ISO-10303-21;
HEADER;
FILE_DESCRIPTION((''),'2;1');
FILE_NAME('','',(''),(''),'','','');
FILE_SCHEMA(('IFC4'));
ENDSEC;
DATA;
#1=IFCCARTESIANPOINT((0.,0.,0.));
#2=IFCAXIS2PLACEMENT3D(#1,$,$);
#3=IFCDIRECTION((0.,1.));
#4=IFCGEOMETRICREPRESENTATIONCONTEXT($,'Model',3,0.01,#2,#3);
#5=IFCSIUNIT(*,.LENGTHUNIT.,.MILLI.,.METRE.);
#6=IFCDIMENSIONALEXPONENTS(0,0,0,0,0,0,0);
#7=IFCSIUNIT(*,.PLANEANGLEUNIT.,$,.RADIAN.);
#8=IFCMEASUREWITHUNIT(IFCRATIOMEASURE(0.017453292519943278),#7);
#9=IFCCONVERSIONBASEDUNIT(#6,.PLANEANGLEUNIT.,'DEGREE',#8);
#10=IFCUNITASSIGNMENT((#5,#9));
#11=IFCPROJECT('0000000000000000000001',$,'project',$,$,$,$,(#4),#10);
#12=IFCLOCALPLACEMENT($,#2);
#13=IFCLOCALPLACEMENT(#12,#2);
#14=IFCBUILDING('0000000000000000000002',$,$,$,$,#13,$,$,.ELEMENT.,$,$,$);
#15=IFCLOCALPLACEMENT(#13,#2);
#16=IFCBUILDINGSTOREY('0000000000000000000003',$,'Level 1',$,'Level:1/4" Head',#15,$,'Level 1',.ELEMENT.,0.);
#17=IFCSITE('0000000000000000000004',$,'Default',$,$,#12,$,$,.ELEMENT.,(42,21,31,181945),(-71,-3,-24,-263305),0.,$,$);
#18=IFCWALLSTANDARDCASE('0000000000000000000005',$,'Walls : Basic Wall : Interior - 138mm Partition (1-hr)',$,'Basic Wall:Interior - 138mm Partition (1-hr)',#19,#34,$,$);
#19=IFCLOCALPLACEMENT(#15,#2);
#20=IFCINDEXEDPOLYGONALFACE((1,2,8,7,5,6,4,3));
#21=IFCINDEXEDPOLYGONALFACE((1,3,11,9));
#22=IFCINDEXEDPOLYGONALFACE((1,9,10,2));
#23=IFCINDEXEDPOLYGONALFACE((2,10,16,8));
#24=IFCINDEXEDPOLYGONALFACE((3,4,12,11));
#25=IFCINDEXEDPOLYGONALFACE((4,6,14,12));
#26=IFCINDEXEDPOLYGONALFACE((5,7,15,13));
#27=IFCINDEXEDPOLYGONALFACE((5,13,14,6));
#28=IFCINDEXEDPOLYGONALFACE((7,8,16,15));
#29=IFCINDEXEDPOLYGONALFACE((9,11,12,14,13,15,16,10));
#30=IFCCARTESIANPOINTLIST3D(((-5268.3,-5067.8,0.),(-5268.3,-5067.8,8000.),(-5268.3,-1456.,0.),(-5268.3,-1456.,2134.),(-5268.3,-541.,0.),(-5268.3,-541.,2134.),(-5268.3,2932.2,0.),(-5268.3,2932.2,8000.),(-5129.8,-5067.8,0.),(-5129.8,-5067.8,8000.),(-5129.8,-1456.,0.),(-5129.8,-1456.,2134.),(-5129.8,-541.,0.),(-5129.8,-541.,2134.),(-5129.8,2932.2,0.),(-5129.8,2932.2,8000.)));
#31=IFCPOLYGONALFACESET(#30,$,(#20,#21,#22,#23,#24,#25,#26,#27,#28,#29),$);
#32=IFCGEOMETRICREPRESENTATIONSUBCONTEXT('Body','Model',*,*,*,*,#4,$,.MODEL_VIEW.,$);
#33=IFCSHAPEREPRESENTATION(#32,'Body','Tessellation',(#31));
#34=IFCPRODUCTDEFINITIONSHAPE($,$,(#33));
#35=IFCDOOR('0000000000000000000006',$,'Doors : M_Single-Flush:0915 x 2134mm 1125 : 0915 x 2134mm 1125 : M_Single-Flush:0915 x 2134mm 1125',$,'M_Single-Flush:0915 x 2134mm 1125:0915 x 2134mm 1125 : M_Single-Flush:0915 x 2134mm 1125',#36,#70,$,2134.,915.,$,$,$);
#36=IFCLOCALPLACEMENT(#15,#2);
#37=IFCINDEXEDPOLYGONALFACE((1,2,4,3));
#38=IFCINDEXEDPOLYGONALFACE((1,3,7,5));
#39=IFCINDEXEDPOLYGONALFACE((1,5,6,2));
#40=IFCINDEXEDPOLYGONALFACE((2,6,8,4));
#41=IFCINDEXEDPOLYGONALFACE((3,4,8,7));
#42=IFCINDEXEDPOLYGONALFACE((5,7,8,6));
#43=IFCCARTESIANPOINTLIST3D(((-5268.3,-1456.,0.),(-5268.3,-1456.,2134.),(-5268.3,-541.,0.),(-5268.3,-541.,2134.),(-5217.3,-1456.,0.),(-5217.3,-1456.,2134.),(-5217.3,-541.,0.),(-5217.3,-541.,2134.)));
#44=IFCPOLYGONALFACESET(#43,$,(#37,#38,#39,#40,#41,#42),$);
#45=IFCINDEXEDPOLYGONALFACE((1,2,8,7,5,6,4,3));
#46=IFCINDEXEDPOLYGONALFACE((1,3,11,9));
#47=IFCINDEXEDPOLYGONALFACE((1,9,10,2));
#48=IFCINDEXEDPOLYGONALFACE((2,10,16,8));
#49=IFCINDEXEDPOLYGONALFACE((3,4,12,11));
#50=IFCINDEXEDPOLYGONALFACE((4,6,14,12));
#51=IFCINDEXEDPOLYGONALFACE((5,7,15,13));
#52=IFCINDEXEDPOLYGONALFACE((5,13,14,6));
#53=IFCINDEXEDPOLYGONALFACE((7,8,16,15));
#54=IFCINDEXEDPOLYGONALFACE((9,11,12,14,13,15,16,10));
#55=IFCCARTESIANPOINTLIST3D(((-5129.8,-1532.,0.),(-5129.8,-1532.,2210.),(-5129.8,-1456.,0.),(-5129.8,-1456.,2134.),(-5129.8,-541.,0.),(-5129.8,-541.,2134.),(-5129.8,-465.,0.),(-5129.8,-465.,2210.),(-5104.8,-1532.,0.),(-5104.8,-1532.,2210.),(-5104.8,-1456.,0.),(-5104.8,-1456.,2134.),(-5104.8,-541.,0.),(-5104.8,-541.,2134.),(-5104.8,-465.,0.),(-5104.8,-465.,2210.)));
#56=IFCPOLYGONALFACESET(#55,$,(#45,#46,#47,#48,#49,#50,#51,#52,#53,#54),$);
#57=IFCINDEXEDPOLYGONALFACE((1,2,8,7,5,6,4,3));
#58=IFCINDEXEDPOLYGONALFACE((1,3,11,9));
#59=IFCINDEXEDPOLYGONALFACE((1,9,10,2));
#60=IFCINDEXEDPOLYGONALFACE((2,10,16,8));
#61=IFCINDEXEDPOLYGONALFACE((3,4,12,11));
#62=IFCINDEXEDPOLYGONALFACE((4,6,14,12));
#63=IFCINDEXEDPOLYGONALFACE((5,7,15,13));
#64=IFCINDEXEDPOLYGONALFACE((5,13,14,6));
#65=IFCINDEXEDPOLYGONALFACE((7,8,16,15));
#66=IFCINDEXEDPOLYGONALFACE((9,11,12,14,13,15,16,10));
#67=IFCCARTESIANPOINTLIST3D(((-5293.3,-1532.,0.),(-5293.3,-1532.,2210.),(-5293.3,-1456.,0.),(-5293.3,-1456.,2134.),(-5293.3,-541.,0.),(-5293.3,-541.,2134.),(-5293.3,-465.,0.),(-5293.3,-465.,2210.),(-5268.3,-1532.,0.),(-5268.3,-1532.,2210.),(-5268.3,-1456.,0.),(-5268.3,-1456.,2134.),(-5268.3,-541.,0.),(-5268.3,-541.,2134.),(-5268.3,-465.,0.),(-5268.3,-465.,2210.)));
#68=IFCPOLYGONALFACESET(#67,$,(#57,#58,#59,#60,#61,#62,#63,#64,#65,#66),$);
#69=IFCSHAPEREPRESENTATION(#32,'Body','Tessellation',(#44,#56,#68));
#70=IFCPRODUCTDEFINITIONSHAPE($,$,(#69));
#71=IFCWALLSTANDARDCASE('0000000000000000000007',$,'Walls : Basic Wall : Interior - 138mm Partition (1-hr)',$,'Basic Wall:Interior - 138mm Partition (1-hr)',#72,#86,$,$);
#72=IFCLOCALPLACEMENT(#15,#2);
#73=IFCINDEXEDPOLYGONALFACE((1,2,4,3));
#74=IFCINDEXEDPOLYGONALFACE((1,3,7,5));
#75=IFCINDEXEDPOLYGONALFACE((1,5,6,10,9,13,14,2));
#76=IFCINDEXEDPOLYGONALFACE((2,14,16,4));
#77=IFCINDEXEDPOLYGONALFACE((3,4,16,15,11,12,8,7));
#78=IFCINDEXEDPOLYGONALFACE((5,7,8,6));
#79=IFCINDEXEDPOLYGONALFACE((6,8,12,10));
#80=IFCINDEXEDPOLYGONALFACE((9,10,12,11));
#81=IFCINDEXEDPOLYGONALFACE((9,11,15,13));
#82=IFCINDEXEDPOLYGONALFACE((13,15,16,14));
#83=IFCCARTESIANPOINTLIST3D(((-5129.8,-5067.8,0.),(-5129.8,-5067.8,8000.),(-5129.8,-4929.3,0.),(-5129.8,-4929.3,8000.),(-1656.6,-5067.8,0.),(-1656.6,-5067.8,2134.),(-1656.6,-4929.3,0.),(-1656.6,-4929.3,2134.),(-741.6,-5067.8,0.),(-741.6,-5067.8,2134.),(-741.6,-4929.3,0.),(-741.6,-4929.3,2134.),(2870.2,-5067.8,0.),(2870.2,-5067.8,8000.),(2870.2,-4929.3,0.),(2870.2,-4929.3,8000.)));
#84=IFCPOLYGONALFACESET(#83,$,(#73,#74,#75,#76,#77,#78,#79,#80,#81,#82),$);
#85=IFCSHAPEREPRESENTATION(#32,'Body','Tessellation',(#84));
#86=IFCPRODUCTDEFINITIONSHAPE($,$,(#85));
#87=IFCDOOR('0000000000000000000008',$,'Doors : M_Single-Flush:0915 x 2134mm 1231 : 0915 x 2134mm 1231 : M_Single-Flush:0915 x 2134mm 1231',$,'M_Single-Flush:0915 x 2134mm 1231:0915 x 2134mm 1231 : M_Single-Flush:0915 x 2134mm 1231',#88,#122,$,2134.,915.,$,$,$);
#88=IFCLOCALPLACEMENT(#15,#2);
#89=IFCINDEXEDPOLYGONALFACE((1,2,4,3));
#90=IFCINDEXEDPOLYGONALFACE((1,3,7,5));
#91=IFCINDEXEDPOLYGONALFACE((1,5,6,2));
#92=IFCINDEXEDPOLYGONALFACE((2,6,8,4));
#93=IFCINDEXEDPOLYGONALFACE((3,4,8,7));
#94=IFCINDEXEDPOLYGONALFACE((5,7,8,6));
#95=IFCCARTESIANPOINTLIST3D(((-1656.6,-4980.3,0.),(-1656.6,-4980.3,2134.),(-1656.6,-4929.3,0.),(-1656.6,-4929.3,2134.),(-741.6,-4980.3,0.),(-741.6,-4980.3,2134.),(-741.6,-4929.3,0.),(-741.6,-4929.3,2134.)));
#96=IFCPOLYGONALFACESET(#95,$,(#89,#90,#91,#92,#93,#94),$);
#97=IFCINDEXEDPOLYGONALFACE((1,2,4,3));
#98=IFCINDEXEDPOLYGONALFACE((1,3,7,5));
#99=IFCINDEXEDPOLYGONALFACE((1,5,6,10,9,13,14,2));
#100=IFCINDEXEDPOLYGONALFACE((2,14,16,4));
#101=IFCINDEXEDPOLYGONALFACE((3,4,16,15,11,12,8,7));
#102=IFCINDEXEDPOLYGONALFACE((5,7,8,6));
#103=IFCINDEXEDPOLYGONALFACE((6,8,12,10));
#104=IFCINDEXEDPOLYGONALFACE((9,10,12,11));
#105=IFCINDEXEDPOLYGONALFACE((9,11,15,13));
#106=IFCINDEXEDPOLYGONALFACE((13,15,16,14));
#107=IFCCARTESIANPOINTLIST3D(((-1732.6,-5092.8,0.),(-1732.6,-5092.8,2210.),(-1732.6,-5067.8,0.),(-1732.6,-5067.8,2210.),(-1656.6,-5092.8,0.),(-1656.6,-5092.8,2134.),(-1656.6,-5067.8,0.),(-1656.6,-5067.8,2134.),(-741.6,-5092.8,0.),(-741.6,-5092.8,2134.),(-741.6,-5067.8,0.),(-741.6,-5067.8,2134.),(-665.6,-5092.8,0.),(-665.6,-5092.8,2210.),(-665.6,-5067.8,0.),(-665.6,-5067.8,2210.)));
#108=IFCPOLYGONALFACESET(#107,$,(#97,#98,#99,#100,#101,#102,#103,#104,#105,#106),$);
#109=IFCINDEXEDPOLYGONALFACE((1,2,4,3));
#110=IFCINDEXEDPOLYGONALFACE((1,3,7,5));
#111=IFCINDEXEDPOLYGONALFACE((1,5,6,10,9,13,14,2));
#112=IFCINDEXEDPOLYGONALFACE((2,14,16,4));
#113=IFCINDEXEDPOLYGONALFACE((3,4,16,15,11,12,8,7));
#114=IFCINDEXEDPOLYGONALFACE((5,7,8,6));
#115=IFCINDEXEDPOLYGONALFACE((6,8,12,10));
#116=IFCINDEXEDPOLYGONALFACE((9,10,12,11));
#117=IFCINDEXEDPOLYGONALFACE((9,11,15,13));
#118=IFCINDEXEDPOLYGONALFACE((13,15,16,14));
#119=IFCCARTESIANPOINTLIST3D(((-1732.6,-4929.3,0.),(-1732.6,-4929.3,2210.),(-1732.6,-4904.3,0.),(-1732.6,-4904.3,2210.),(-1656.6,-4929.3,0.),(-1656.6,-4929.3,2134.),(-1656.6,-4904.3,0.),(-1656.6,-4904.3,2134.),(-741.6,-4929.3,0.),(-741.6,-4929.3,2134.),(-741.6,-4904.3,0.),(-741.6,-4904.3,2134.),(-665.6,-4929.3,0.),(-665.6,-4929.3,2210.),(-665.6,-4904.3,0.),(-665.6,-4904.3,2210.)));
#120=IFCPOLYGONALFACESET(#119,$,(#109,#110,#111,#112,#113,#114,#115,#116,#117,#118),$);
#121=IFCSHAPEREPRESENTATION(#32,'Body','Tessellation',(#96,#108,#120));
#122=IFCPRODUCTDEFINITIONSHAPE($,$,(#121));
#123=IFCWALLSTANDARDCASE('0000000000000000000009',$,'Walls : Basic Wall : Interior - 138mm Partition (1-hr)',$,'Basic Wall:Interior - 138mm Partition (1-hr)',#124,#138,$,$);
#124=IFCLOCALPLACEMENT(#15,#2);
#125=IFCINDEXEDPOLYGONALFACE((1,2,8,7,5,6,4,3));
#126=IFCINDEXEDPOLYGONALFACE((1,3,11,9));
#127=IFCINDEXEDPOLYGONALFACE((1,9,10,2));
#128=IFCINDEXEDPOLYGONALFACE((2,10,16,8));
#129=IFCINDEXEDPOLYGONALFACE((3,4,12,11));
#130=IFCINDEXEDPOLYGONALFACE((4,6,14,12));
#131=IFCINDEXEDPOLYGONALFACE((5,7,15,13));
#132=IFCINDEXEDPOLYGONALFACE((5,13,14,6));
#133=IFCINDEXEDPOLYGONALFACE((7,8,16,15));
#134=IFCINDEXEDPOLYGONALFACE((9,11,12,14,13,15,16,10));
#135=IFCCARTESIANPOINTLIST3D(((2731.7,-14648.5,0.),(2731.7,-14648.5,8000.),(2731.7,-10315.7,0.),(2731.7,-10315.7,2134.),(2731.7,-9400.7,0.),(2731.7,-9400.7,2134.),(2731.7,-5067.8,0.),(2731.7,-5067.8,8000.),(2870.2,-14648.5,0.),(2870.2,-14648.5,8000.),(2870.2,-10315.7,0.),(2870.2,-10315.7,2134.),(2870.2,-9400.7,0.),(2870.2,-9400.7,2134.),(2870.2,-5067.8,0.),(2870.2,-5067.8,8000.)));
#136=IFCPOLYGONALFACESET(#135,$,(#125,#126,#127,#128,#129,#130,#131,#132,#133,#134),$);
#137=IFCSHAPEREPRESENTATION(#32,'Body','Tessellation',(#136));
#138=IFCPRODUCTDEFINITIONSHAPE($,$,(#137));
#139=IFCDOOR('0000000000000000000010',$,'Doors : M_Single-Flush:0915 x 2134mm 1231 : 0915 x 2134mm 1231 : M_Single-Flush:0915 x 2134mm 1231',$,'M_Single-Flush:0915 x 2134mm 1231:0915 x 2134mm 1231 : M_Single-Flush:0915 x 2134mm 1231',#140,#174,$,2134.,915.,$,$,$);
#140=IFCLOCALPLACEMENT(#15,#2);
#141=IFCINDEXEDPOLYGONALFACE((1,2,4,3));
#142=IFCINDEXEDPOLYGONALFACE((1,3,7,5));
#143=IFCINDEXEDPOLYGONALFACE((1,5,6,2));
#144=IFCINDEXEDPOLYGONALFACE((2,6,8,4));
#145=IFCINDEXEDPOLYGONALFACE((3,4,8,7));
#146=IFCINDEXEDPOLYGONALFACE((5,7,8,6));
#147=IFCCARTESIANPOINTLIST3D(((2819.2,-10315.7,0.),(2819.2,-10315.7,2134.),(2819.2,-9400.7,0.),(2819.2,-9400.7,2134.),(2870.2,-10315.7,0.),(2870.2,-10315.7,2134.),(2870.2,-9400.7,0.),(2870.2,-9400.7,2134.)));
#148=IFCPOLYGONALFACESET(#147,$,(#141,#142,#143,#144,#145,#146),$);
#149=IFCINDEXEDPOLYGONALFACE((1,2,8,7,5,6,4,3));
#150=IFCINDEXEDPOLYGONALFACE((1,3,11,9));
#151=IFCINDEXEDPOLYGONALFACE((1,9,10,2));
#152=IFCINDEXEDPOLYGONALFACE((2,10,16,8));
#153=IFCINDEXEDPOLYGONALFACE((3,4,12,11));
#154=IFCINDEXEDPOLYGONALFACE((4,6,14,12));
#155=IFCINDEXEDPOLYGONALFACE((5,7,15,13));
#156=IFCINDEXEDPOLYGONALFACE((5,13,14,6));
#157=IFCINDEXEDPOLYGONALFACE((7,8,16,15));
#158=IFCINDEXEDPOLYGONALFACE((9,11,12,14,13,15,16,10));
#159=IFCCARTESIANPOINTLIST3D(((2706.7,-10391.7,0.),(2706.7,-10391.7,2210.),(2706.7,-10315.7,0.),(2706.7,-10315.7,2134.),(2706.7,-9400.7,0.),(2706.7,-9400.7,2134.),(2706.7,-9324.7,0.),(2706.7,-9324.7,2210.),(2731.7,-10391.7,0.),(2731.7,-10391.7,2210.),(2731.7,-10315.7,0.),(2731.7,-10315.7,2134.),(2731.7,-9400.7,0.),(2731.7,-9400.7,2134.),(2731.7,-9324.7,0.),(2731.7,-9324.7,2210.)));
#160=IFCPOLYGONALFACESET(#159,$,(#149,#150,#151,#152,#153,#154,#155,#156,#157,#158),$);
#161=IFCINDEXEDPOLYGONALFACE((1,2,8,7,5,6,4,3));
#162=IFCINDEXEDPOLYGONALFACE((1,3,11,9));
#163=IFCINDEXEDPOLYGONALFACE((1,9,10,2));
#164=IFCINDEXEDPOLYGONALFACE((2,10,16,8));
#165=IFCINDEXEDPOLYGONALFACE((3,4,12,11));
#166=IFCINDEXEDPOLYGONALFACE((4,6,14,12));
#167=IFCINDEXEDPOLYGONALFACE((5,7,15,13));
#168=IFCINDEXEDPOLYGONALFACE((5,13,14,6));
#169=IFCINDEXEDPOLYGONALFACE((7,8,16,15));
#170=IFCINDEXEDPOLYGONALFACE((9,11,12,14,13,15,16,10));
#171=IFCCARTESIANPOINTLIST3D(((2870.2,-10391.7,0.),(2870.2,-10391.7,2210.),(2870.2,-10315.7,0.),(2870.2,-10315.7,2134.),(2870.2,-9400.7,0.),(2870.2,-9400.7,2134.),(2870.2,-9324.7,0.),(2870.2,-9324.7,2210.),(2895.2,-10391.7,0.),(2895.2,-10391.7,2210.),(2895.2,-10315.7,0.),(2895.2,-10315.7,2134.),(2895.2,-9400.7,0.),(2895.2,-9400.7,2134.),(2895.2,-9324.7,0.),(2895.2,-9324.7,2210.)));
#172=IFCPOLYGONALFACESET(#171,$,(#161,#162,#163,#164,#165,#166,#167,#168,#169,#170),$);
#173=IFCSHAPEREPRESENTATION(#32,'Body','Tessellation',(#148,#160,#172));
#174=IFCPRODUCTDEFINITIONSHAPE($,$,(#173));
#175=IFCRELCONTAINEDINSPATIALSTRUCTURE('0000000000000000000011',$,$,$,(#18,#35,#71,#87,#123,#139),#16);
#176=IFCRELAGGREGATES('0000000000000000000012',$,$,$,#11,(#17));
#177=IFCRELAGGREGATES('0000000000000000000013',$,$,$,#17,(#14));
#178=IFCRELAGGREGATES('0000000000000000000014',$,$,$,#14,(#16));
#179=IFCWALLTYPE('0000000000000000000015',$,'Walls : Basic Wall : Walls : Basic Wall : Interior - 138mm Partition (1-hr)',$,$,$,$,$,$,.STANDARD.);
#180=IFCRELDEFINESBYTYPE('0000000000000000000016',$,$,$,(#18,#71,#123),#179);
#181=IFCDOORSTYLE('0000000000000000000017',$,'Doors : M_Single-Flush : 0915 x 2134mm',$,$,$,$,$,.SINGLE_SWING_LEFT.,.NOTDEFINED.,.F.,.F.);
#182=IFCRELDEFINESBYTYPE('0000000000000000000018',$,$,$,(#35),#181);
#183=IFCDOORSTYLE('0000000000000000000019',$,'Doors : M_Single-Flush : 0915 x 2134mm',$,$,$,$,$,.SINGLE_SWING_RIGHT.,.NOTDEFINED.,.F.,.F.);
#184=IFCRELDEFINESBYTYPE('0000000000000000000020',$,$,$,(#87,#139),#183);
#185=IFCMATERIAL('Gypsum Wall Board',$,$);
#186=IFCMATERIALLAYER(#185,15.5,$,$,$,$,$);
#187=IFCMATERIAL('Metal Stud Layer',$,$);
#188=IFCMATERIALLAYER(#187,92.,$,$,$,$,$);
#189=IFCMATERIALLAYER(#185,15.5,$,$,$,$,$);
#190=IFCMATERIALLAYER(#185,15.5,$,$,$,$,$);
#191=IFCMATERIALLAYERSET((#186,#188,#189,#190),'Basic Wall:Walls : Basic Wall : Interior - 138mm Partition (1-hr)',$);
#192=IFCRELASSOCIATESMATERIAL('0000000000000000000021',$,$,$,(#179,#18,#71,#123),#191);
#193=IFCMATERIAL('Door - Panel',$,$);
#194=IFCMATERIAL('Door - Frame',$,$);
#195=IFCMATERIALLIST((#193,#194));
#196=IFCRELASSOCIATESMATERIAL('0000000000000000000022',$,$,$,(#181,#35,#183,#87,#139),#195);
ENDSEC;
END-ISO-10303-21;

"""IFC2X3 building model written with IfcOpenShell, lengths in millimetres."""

from ifc_helpers import new_model, entity, si_unit, converted_unit, direction, frame, frame_2d, origin, origin_2d_with_axis, place, context, subcontext, project, spatial, polyline, rectangle, outline, extrude, source, transform, mapped, material, material_list, layer, layer_set, layer_usage, type_object, type_shapes, element, fill, save


model = new_model("IFC2X3")

# Units and contexts
model_context = context("Model", 3, precision=0.01, world=origin(), true_north=direction((0.0, 1.0)))
body_context = subcontext(model_context, "Body", "Model", "MODEL_VIEW")
ifc_project = project(units=[si_unit("LENGTHUNIT", "METRE", prefix="MILLI"), converted_unit("PLANEANGLEUNIT", "DEGREE", entity("IfcRatioMeasure", 0.017453292519943278), si_unit("PLANEANGLEUNIT", "RADIAN"), dimensions=[0, 0, 0, 0, 0, 0, 0])], contexts=[model_context])

# Site, building, storey
site_placement = place(None, origin())
site = spatial("IfcSite", under=ifc_project, at=site_placement, Name="Default", CompositionType="ELEMENT", RefLatitude=(42, 21, 31, 181945), RefLongitude=(-71, -3, -24, -263305), RefElevation=0.0)
building_placement = place(site_placement, origin())
building = spatial("IfcBuilding", under=site, at=building_placement, CompositionType="ELEMENT")
storey_placement = place(building_placement, origin())
storey = spatial("IfcBuildingStorey", under=building, at=storey_placement, Name="Level 1", ObjectType="Level:1/4\" Head", LongName="Level 1", CompositionType="ELEMENT", Elevation=0.0)

# Shared definitions
ifc_material_1 = material(Name="Metal Stud Layer")
ifc_material_2 = material(Name="Gypsum Wall Board")

# Shared definitions
ifc_material_3 = material(Name="Door - Panel")
ifc_material_4 = material(Name="Door - Frame")
ifc_material_list = material_list([ifc_material_3, ifc_material_4])

# Shared definitions
ifc_layer_1 = layer(ifc_material_2, 15.5)
ifc_layer_2 = layer(ifc_material_1, 92.0)
ifc_layer_3 = layer(ifc_material_2, 15.5)
ifc_layer_4 = layer(ifc_material_2, 15.5)
ifc_layer_set_1 = layer_set([ifc_layer_1, ifc_layer_2, ifc_layer_3, ifc_layer_4], Name="Basic Wall:Walls : Basic Wall : Interior - 138mm Partition (1-hr)")
ifc_layer_usage_1 = layer_usage(ifc_layer_set_1, "AXIS2", "NEGATIVE", 69.2)
wall_type_1 = type_object("IfcWallType", Name="Walls : Basic Wall : Walls : Basic Wall : Interior - 138mm Partition (1-hr)", PredefinedType="STANDARD", material=ifc_layer_set_1)

# Walls, openings, doors
wall_1_placement = place(storey_placement, frame((-5199.1, 2932.2, 0.0), z_axis=(0.0, 0.0, 1.0), x_axis=(0.0, -1.0, 0.0)))
wall_1 = element("IfcWallStandardCase", 1, at=wall_1_placement, inside=storey, type_object=wall_type_1, material=ifc_layer_usage_1, Name="Walls : Basic Wall : Interior - 138mm Partition (1-hr)", ObjectType="Basic Wall:Interior - 138mm Partition (1-hr)", context=body_context, shape_type="SweptSolid", body=[
    extrude(rectangle(XDim=8000.0, YDim=138.5, at=frame_2d((4000.0, 0.0), x_axis=(-1.0, 0.0))), origin(), (0.0, 0.0, 1.0), 8000.0),
])
opening_1_placement = place(wall_1_placement, frame((4388.3, -70.6, 0.0), z_axis=(0.0, 0.0, 1.0), x_axis=(0.0, 1.0, 0.0)))
opening_1 = element("IfcOpeningElement", 2, at=opening_1_placement, cuts=wall_1, ObjectType="Opening", context=body_context, shape_type="SweptSolid", body=[
    extrude(rectangle(XDim=2134.0, YDim=915.0, at=frame_2d((0.0, 0.0), x_axis=(0.0, 1.0))), frame((0.0, 457.5, 1067.0), z_axis=(1.0, 0.0, 0.0), x_axis=(0.0, 1.0, 0.0)), (0.0, 0.0, 1.0), 141.3),
])
door_style_1 = type_object("IfcDoorStyle", Name="Doors : M_Single-Flush : 0915 x 2134mm", ConstructionType="NOTDEFINED", OperationType="SINGLE_SWING_LEFT", ParameterTakesPrecedence=False, Sizeable=False, material=ifc_material_list)
shared_shape_1 = source(origin(), body_context, "Body", "SweptSolid", [
    extrude(rectangle(XDim=51.0, YDim=915.0, at=origin_2d_with_axis()), frame((457.5, 114.4, 0.0), z_axis=(0.0, 0.0, 1.0), x_axis=(0.0, 1.0, 0.0)), (0.0, 0.0, 1.0), 2134.0),
    extrude(outline(polyline([(-1086.0, -533.5), (1124.0, -533.5), (1124.0, 533.5), (-1086.0, 533.5), (-1086.0, 457.5), (1048.0, 457.5), (1048.0, -457.5), (-1086.0, -457.5), (-1086.0, -533.5)])), frame((457.5, -23.6, 1086.0), z_axis=(0.0, 1.0, 0.0), x_axis=(0.0, 0.0, 1.0)), (0.0, 0.0, 1.0), 25.0),
    extrude(outline(polyline([(-533.5, -1124.0), (533.5, -1124.0), (533.5, 1086.0), (457.5, 1086.0), (457.5, -1048.0), (-457.5, -1048.0), (-457.5, 1086.0), (-533.5, 1086.0), (-533.5, -1124.0)])), frame((457.5, 139.9, 1086.0), z_axis=(0.0, 1.0, 0.0), x_axis=(1.0, 0.0, 0.0)), (0.0, 0.0, 1.0), 25.0),
])
type_shapes(door_style_1, [shared_shape_1])
door_1_placement = place(opening_1_placement, frame((141.3, 0.0, 0.0), z_axis=(0.0, 0.0, 1.0), x_axis=(0.0, 1.0, 0.0)))
door_1 = element("IfcDoor", 3, at=door_1_placement, inside=storey, type_object=door_style_1, material=ifc_material_list, Name="Doors : M_Single-Flush:0915 x 2134mm 1125 : 0915 x 2134mm 1125 : M_Single-Flush:0915 x 2134mm 1125", ObjectType="M_Single-Flush:0915 x 2134mm 1125:0915 x 2134mm 1125 : M_Single-Flush:0915 x 2134mm 1125", OverallHeight=2134.0, OverallWidth=915.0, context=body_context, shape_type="MappedRepresentation", body=[
    mapped(shared_shape_1, transform((0.0, 0.0, 0.0), scale=1.0)),
])
fill(opening_1, door_1)
wall_2_placement = place(storey_placement, frame((-5129.8, -4998.5, 0.0)))
wall_2 = element("IfcWallStandardCase", 4, at=wall_2_placement, inside=storey, type_object=wall_type_1, material=ifc_layer_usage_1, Name="Walls : Basic Wall : Interior - 138mm Partition (1-hr)", ObjectType="Basic Wall:Interior - 138mm Partition (1-hr)", context=body_context, shape_type="SweptSolid", body=[
    extrude(rectangle(XDim=8000.0, YDim=138.5, at=frame_2d((4000.0, 0.0), x_axis=(-1.0, 0.0))), origin(), (0.0, 0.0, 1.0), 8000.0),
])
opening_2_placement = place(wall_2_placement, frame((3473.2, -70.6, 0.0)))
opening_2 = element("IfcOpeningElement", 5, at=opening_2_placement, cuts=wall_2, ObjectType="Opening", context=body_context, shape_type="SweptSolid", body=[
    extrude(rectangle(XDim=2134.0, YDim=915.0, at=origin_2d_with_axis()), frame((457.5, 0.0, 1067.0), z_axis=(0.0, 1.0, 0.0), x_axis=(0.0, 0.0, -1.0)), (0.0, 0.0, 1.0), 141.3),
])
door_style_2 = type_object("IfcDoorStyle", Name="Doors : M_Single-Flush : 0915 x 2134mm", ConstructionType="NOTDEFINED", OperationType="SINGLE_SWING_RIGHT", ParameterTakesPrecedence=False, Sizeable=False, material=ifc_material_list)
shared_shape_2 = source(origin(), body_context, "Body", "SweptSolid", [
    extrude(rectangle(XDim=915.0, YDim=51.0, at=origin_2d_with_axis()), frame((457.5, -26.9, 0.0), z_axis=(0.0, 0.0, 1.0), x_axis=(-1.0, 0.0, 0.0)), (0.0, 0.0, 1.0), 2134.0),
    extrude(outline(polyline([(-533.5, -1086.0), (-457.5, -1086.0), (-457.5, 1048.0), (457.5, 1048.0), (457.5, -1086.0), (533.5, -1086.0), (533.5, 1124.0), (-533.5, 1124.0), (-533.5, -1086.0)])), frame((457.5, -164.9, 1086.0), z_axis=(0.0, 1.0, 0.0), x_axis=(-1.0, 0.0, 0.0)), (0.0, 0.0, 1.0), 25.0),
    extrude(outline(polyline([(-1124.0, -533.5), (1086.0, -533.5), (1086.0, -457.5), (-1048.0, -457.5), (-1048.0, 457.5), (1086.0, 457.5), (1086.0, 533.5), (-1124.0, 533.5), (-1124.0, -533.5)])), frame((457.5, -1.4, 1086.0), z_axis=(0.0, 1.0, 0.0), x_axis=(0.0, 0.0, -1.0)), (0.0, 0.0, 1.0), 25.0),
])
type_shapes(door_style_2, [shared_shape_2])
door_2_placement = place(opening_2_placement, frame((0.0, 141.3, 0.0)))
door_2 = element("IfcDoor", 6, at=door_2_placement, inside=storey, type_object=door_style_2, material=ifc_material_list, Name="Doors : M_Single-Flush:0915 x 2134mm 1231 : 0915 x 2134mm 1231 : M_Single-Flush:0915 x 2134mm 1231", ObjectType="M_Single-Flush:0915 x 2134mm 1231:0915 x 2134mm 1231 : M_Single-Flush:0915 x 2134mm 1231", OverallHeight=2134.0, OverallWidth=915.0, context=body_context, shape_type="MappedRepresentation", body=[
    mapped(shared_shape_2, transform((0.0, 0.0, 0.0), scale=1.0)),
])
fill(opening_2, door_2)
wall_3_placement = place(storey_placement, frame((2800.9, -5067.8, 0.0), z_axis=(0.0, 0.0, 1.0), x_axis=(0.0, -1.0, 0.0)))
wall_3 = element("IfcWallStandardCase", 7, at=wall_3_placement, inside=storey, type_object=wall_type_1, material=ifc_layer_usage_1, Name="Walls : Basic Wall : Interior - 138mm Partition (1-hr)", ObjectType="Basic Wall:Interior - 138mm Partition (1-hr)", context=body_context, shape_type="SweptSolid", body=[
    extrude(rectangle(XDim=9580.8, YDim=138.5, at=frame_2d((4790.4, 0.0), x_axis=(1.0, 0.0))), origin(), (0.0, 0.0, 1.0), 8000.0),
])
opening_3_placement = place(wall_3_placement, frame((5247.9, -70.6, 0.0), z_axis=(0.0, 0.0, 1.0), x_axis=(0.0, 1.0, 0.0)))
opening_3 = element("IfcOpeningElement", 8, at=opening_3_placement, cuts=wall_3, ObjectType="Opening", context=body_context, shape_type="SweptSolid", body=[
    extrude(rectangle(XDim=2134.0, YDim=915.0, at=origin_2d_with_axis()), frame((0.0, 457.5, 1067.0), z_axis=(1.0, 0.0, 0.0), x_axis=(0.0, 0.0, -1.0)), (0.0, 0.0, 1.0), 141.3),
])
door_3_placement = place(opening_3_placement, frame((141.3, 915.0, 0.0), z_axis=(0.0, 0.0, 1.0), x_axis=(0.0, -1.0, 0.0)))
door_3 = element("IfcDoor", 9, at=door_3_placement, inside=storey, type_object=door_style_2, material=ifc_material_list, Name="Doors : M_Single-Flush:0915 x 2134mm 1231 : 0915 x 2134mm 1231 : M_Single-Flush:0915 x 2134mm 1231", ObjectType="M_Single-Flush:0915 x 2134mm 1231:0915 x 2134mm 1231 : M_Single-Flush:0915 x 2134mm 1231", OverallHeight=2134.0, OverallWidth=915.0, context=body_context, shape_type="MappedRepresentation", body=[
    mapped(shared_shape_2, transform((0.0, 0.0, 0.0), scale=1.0)),
])
fill(opening_3, door_3)

save(model, "model.ifc")
